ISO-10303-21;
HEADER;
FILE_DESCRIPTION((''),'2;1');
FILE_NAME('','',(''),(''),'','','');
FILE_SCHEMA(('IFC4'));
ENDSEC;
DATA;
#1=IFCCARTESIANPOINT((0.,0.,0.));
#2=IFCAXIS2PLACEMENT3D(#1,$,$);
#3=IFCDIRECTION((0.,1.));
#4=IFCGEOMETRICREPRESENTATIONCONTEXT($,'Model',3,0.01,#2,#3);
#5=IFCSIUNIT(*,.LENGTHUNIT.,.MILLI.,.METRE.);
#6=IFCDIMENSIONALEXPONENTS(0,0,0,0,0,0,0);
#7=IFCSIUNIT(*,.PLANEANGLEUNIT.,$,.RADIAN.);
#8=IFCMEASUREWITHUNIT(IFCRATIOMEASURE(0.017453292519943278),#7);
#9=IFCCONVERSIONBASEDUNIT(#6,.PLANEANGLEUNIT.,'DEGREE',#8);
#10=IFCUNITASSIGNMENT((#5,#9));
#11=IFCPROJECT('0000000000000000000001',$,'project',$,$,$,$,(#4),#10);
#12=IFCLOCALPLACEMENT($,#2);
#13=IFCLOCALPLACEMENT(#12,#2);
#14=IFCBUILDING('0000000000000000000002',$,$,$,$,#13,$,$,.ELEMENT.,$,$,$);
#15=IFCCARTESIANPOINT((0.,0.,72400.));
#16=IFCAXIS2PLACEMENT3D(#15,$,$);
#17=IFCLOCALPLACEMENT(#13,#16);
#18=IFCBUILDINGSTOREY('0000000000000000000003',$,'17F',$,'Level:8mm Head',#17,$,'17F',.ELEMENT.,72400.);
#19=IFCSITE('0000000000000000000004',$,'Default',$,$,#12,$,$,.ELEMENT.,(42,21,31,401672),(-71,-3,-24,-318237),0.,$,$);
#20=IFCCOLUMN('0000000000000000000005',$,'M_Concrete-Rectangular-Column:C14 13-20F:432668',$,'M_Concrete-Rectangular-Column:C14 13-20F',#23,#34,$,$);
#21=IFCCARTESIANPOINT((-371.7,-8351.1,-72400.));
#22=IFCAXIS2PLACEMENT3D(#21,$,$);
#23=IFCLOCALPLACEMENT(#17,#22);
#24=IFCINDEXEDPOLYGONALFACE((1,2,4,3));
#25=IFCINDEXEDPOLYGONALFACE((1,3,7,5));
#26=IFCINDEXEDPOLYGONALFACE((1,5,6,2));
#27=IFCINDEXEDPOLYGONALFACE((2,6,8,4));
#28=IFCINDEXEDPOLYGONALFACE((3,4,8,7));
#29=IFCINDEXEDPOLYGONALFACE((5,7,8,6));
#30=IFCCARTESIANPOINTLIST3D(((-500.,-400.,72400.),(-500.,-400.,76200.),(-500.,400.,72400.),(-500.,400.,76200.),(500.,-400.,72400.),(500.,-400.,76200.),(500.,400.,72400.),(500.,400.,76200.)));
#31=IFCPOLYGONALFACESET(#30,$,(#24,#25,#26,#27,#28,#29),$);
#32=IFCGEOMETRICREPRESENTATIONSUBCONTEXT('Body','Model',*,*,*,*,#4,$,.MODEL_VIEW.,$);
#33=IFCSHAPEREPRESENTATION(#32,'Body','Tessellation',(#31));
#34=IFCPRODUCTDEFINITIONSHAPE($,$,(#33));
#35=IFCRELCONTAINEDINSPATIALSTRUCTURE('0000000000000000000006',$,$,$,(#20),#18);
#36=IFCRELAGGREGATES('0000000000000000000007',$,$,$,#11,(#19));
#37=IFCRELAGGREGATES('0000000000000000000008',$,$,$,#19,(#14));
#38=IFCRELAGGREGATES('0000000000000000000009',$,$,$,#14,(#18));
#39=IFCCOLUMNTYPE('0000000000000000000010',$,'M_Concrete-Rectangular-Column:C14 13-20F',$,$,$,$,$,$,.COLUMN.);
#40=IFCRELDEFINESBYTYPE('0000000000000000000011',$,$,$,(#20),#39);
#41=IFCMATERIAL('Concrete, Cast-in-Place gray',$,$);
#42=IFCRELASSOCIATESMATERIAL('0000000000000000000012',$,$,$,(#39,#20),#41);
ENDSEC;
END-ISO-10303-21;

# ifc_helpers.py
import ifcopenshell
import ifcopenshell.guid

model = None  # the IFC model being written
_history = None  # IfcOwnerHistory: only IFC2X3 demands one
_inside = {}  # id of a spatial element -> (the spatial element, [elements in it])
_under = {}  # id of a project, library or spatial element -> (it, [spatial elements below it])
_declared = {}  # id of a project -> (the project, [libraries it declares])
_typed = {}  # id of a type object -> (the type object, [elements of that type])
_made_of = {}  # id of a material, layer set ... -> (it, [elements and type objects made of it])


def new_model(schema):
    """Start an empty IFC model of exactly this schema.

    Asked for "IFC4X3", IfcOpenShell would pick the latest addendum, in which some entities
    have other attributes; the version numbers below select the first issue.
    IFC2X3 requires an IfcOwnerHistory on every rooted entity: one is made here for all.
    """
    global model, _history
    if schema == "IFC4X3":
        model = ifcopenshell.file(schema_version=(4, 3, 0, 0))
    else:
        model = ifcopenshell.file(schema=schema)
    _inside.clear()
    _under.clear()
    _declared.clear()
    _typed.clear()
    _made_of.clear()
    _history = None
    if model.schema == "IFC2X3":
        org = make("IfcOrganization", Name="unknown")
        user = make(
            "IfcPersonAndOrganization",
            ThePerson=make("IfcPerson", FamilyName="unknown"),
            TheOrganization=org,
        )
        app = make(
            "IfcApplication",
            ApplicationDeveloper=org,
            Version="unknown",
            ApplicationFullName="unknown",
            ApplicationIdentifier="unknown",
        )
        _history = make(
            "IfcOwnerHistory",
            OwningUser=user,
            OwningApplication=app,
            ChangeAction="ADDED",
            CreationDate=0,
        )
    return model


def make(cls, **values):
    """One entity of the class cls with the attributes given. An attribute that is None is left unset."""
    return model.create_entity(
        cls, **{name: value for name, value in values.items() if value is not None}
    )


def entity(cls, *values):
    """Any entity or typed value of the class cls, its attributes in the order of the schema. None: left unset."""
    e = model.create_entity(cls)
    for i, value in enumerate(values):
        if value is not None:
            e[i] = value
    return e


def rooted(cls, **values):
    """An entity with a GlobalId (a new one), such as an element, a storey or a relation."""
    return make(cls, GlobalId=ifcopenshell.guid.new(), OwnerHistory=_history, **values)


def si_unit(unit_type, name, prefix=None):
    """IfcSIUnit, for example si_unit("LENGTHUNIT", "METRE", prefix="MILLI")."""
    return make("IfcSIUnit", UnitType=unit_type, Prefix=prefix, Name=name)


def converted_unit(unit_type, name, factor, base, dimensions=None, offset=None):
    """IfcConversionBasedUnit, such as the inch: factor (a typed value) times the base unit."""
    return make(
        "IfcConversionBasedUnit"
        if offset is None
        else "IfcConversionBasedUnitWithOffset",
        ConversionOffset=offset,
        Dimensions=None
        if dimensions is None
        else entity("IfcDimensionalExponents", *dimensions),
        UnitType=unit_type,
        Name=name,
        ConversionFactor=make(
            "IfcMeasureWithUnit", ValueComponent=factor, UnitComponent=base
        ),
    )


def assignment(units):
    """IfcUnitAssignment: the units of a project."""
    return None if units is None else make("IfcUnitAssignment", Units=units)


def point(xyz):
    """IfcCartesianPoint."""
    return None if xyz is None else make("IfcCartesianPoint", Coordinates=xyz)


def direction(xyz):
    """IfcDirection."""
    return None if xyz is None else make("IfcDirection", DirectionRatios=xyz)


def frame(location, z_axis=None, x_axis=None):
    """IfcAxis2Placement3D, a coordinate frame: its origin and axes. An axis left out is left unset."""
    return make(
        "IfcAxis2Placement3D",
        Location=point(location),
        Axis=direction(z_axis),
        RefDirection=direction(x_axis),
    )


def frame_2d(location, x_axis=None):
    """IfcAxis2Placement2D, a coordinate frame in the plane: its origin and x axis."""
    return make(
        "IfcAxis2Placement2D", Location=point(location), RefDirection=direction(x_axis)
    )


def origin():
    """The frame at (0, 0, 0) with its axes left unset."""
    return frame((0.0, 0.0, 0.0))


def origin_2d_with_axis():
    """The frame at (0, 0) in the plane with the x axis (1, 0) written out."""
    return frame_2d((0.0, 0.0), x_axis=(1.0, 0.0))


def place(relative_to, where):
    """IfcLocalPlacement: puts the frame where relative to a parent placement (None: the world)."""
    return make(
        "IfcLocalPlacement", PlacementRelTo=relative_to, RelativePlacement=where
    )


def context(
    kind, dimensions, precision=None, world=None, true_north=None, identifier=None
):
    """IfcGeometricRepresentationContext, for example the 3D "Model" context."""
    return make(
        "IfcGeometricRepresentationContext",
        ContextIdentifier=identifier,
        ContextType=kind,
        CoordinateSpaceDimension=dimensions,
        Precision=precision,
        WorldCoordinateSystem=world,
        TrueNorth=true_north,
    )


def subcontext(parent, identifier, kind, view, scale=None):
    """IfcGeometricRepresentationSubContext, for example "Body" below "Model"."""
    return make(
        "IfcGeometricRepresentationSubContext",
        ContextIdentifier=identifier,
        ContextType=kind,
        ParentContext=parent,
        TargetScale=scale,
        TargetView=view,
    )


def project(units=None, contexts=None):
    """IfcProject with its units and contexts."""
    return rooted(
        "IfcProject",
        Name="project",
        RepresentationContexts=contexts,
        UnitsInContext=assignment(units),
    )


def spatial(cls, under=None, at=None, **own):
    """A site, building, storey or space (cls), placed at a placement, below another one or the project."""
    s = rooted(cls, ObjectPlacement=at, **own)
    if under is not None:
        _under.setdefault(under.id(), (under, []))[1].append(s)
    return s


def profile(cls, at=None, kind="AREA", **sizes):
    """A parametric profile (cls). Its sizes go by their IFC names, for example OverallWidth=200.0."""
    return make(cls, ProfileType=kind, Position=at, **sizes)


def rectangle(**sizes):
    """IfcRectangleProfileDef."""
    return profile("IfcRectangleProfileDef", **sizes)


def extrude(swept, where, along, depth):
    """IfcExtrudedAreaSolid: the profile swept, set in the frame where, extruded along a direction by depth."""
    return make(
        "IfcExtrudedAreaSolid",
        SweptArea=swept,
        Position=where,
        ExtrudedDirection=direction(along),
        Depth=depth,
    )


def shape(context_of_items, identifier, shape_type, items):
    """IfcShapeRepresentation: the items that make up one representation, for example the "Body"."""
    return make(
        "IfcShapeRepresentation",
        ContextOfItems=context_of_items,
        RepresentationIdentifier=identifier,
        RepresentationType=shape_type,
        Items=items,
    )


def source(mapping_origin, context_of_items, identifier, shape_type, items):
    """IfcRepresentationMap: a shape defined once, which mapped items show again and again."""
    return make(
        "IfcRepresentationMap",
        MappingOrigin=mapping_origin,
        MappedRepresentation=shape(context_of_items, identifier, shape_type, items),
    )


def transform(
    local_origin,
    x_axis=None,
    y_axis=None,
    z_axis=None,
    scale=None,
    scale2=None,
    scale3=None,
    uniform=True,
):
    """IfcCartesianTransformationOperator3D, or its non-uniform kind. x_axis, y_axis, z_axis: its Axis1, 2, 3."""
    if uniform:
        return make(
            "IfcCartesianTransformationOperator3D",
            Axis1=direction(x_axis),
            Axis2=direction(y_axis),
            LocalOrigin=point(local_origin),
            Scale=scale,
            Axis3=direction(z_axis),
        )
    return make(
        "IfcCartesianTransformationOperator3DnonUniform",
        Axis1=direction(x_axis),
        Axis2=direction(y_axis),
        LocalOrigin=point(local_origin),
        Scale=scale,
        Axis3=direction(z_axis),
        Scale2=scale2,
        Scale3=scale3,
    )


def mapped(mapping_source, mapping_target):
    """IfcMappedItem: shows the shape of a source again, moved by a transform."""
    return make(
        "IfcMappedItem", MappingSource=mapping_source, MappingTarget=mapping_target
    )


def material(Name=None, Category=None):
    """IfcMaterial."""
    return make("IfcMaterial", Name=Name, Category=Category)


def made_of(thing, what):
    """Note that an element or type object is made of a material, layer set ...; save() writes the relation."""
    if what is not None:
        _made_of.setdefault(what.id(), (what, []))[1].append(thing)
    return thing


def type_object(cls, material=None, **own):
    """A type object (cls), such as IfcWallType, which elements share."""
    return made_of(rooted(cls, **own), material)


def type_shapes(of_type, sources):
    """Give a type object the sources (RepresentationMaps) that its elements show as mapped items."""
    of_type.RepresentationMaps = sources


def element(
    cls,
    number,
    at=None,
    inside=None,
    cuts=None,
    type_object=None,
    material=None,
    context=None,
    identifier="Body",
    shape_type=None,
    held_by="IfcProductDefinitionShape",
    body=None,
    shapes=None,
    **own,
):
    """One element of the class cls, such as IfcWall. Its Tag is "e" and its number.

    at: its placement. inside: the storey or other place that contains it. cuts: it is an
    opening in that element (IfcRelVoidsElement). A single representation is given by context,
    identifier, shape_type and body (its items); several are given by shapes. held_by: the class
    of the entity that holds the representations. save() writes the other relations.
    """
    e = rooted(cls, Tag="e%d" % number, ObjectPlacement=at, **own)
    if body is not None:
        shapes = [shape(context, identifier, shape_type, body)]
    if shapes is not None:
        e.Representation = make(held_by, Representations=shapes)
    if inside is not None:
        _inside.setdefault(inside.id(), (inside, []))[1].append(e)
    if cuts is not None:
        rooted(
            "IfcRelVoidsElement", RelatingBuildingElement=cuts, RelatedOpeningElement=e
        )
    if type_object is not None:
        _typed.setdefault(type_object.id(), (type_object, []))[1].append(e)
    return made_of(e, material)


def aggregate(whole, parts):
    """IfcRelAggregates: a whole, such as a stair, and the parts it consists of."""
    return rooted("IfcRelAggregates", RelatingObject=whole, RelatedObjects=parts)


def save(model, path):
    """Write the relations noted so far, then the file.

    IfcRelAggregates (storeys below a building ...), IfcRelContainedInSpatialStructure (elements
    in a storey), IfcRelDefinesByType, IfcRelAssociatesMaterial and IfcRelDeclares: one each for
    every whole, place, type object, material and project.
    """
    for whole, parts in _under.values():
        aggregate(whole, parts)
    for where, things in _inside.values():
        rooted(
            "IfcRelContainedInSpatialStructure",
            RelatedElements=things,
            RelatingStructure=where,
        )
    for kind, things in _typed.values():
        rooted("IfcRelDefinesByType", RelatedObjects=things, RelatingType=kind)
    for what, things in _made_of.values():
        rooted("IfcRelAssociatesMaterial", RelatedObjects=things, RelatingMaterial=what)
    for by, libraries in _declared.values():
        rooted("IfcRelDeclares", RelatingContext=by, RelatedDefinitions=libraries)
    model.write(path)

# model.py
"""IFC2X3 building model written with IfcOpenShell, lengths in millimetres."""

from ifc_helpers import new_model, entity, si_unit, converted_unit, direction, frame, origin, origin_2d_with_axis, place, context, subcontext, project, spatial, rectangle, extrude, source, transform, mapped, material, type_object, type_shapes, element, save


model = new_model("IFC2X3")

# Units and contexts
model_context = context("Model", 3, precision=0.01, world=origin(), true_north=direction((0.0, 1.0)))
body_context = subcontext(model_context, "Body", "Model", "MODEL_VIEW")
ifc_project = project(units=[si_unit("LENGTHUNIT", "METRE", prefix="MILLI"), converted_unit("PLANEANGLEUNIT", "DEGREE", entity("IfcRatioMeasure", 0.017453292519943278), si_unit("PLANEANGLEUNIT", "RADIAN"), dimensions=[0, 0, 0, 0, 0, 0, 0])], contexts=[model_context])

# Site, building, storey
site_placement = place(None, origin())
site = spatial("IfcSite", under=ifc_project, at=site_placement, Name="Default", CompositionType="ELEMENT", RefLatitude=(42, 21, 31, 401672), RefLongitude=(-71, -3, -24, -318237), RefElevation=0.0)
building_placement = place(site_placement, origin())
building = spatial("IfcBuilding", under=site, at=building_placement, CompositionType="ELEMENT")
storey_placement = place(building_placement, frame((0.0, 0.0, 72400.0)))
storey = spatial("IfcBuildingStorey", under=building, at=storey_placement, Name="17F", ObjectType="Level:8mm Head", LongName="17F", CompositionType="ELEMENT", Elevation=72400.0)

# Column
ifc_material = material(Name="Concrete, Cast-in-Place gray")
column_type = type_object("IfcColumnType", Name="M_Concrete-Rectangular-Column:C14 13-20F", PredefinedType="COLUMN", material=ifc_material)
shared_shape = source(origin(), body_context, "Body", "SweptSolid", [
    extrude(rectangle(XDim=800.0, YDim=1000.0, at=origin_2d_with_axis()), frame((0.0, 0.0, 72400.0), z_axis=(0.0, 0.0, 1.0), x_axis=(0.0, -1.0, 0.0)), (0.0, 0.0, 1.0), 3800.0),
])
type_shapes(column_type, [shared_shape])
column_placement = place(storey_placement, frame((-371.7, -8351.1, -72400.0)))
element("IfcColumn", 1, at=column_placement, inside=storey, type_object=column_type, material=ifc_material, Name="M_Concrete-Rectangular-Column:C14 13-20F:432668", ObjectType="M_Concrete-Rectangular-Column:C14 13-20F", context=body_context, shape_type="MappedRepresentation", body=[
    mapped(shared_shape, transform((0.0, 0.0, 0.0), scale=1.0)),
])

save(model, "model.ifc")
